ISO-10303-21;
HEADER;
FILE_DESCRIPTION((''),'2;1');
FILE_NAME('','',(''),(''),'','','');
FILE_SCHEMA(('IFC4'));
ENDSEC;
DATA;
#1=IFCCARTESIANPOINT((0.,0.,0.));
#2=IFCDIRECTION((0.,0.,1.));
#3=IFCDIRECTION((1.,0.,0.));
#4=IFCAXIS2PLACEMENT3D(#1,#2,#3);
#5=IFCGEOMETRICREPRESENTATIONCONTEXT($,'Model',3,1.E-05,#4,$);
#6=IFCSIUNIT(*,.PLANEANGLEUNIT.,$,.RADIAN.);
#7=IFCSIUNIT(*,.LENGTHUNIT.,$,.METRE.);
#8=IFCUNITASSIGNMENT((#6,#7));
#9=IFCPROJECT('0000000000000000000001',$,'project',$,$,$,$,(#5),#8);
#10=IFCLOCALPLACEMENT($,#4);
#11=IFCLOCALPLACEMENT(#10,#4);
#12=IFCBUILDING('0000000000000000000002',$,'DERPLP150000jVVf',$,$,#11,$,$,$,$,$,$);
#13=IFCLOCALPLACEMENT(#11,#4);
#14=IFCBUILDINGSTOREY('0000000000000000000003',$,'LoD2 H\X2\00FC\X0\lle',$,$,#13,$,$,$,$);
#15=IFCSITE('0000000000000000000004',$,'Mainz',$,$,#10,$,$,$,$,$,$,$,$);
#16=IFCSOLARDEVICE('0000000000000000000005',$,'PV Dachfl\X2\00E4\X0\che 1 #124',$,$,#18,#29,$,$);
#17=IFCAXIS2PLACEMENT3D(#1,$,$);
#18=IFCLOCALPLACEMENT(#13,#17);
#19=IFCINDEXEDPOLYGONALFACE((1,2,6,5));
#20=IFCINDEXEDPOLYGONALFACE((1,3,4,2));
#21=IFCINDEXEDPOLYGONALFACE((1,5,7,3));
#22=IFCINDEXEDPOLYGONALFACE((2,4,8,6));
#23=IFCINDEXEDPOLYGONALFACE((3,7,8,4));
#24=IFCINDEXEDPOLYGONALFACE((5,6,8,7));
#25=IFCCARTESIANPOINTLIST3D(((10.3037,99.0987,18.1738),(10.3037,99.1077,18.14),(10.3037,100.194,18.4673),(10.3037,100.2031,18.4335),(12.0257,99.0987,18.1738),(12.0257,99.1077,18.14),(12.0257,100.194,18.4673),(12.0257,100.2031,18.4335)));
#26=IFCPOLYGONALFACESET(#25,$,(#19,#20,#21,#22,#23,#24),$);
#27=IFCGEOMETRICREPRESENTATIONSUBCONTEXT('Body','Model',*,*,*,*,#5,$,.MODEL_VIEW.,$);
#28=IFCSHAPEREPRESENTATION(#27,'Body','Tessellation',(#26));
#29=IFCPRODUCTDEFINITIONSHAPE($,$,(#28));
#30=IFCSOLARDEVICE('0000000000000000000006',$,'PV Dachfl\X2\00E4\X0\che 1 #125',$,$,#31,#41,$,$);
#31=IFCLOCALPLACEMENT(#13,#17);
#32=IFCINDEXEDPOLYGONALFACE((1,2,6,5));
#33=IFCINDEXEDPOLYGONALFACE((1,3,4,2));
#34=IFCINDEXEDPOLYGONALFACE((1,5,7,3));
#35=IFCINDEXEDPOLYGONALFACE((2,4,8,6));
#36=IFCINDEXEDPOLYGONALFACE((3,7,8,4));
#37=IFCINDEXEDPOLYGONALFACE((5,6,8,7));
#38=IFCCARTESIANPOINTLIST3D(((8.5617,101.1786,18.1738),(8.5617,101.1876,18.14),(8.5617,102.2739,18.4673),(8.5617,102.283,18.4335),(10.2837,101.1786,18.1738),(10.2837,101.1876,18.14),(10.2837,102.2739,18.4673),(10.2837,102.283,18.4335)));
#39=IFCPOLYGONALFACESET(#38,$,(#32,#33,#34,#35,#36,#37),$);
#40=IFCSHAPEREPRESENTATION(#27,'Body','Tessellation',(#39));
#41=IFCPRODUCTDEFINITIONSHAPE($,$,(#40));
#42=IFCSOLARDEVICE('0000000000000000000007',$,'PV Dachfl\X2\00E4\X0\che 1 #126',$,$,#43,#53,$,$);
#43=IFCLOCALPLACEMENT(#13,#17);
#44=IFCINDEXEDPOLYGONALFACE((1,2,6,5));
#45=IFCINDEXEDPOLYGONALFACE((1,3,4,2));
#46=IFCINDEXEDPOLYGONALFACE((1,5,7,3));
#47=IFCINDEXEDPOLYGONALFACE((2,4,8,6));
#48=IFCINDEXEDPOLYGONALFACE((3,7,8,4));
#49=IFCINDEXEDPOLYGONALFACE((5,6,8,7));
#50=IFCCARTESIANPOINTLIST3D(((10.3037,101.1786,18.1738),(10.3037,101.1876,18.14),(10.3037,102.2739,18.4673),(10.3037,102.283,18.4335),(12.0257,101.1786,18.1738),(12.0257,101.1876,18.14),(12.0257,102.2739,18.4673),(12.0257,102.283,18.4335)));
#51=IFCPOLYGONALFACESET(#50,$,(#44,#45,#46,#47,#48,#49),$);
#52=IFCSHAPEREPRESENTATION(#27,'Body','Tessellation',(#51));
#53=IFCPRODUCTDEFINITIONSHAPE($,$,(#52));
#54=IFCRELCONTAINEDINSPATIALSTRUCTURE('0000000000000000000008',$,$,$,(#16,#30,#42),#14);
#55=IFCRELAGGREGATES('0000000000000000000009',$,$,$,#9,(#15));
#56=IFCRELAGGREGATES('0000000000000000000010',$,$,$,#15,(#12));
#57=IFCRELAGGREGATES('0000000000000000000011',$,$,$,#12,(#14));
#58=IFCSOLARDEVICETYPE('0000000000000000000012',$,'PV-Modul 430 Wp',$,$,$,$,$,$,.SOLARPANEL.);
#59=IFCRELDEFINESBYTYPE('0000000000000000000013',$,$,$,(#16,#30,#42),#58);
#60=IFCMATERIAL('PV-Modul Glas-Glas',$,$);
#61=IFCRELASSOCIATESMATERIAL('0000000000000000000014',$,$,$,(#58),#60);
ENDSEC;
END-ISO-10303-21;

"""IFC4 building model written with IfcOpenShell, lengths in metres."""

from ifc_helpers import new_model, si_unit, frame, frame_2d, origin, origin_with_axes, place, context, subcontext, project, spatial, rectangle, extrude, source, transform, mapped, material, type_object, type_shapes, element, save


model = new_model("IFC4")

# Units and contexts
model_context = context("Model", 3, precision=1e-05, world=origin_with_axes())
body_context = subcontext(model_context, "Body", "Model", "MODEL_VIEW")
ifc_project = project(units=[si_unit("PLANEANGLEUNIT", "RADIAN"), si_unit("LENGTHUNIT", "METRE")], contexts=[model_context])

# Site, building, storey
site_placement = place(None, origin_with_axes())
site = spatial("IfcSite", under=ifc_project, at=site_placement, Name="Mainz")
building_placement = place(site_placement, origin_with_axes())
building = spatial("IfcBuilding", under=site, at=building_placement, Name="DERPLP150000jVVf")
storey_placement = place(building_placement, origin_with_axes())
storey = spatial("IfcBuildingStorey", under=building, at=storey_placement, Name="LoD2 Hülle")

# Solar devices
ifc_material = material(Name="PV-Modul Glas-Glas")
solar_device_type = type_object("IfcSolarDeviceType", Name="PV-Modul 430 Wp", PredefinedType="SOLARPANEL", material=ifc_material)
shared_shape = source(origin_with_axes(), body_context, "Body", "SweptSolid", [
    extrude(rectangle(XDim=1.722, YDim=1.134, at=frame_2d((0.861, 0.567))), origin(), (0.0, 0.0, 1.0), 0.035),
])
type_shapes(solar_device_type, [shared_shape])
for number, where, z_axis, x_axis, name in (
    (1, (10.3037, 99.1077, 18.14), (0.0, -0.258819, 0.965926), (1.0, 0.0, 0.0), "PV Dachfläche 1 #124"),
    (2, (8.5617, 101.1876, 18.14), (0.0, -0.258819, 0.965926), (1.0, 0.0, 0.0), "PV Dachfläche 1 #125"),
    (3, (10.3037, 101.1876, 18.14), (0.0, -0.258819, 0.965926), (1.0, 0.0, 0.0), "PV Dachfläche 1 #126"),
):
    element("IfcSolarDevice", number, at=place(storey_placement, frame(where, z_axis=z_axis, x_axis=x_axis)), inside=storey, type_object=solar_device_type, Name=name, context=body_context, shape_type="MappedRepresentation", body=[
        mapped(shared_shape, transform((0.0, 0.0, 0.0), x_axis=(1.0, 0.0, 0.0), y_axis=(0.0, 1.0, 0.0), z_axis=(0.0, 0.0, 1.0), scale=1.0)),
    ])

save(model, "model.ifc")
